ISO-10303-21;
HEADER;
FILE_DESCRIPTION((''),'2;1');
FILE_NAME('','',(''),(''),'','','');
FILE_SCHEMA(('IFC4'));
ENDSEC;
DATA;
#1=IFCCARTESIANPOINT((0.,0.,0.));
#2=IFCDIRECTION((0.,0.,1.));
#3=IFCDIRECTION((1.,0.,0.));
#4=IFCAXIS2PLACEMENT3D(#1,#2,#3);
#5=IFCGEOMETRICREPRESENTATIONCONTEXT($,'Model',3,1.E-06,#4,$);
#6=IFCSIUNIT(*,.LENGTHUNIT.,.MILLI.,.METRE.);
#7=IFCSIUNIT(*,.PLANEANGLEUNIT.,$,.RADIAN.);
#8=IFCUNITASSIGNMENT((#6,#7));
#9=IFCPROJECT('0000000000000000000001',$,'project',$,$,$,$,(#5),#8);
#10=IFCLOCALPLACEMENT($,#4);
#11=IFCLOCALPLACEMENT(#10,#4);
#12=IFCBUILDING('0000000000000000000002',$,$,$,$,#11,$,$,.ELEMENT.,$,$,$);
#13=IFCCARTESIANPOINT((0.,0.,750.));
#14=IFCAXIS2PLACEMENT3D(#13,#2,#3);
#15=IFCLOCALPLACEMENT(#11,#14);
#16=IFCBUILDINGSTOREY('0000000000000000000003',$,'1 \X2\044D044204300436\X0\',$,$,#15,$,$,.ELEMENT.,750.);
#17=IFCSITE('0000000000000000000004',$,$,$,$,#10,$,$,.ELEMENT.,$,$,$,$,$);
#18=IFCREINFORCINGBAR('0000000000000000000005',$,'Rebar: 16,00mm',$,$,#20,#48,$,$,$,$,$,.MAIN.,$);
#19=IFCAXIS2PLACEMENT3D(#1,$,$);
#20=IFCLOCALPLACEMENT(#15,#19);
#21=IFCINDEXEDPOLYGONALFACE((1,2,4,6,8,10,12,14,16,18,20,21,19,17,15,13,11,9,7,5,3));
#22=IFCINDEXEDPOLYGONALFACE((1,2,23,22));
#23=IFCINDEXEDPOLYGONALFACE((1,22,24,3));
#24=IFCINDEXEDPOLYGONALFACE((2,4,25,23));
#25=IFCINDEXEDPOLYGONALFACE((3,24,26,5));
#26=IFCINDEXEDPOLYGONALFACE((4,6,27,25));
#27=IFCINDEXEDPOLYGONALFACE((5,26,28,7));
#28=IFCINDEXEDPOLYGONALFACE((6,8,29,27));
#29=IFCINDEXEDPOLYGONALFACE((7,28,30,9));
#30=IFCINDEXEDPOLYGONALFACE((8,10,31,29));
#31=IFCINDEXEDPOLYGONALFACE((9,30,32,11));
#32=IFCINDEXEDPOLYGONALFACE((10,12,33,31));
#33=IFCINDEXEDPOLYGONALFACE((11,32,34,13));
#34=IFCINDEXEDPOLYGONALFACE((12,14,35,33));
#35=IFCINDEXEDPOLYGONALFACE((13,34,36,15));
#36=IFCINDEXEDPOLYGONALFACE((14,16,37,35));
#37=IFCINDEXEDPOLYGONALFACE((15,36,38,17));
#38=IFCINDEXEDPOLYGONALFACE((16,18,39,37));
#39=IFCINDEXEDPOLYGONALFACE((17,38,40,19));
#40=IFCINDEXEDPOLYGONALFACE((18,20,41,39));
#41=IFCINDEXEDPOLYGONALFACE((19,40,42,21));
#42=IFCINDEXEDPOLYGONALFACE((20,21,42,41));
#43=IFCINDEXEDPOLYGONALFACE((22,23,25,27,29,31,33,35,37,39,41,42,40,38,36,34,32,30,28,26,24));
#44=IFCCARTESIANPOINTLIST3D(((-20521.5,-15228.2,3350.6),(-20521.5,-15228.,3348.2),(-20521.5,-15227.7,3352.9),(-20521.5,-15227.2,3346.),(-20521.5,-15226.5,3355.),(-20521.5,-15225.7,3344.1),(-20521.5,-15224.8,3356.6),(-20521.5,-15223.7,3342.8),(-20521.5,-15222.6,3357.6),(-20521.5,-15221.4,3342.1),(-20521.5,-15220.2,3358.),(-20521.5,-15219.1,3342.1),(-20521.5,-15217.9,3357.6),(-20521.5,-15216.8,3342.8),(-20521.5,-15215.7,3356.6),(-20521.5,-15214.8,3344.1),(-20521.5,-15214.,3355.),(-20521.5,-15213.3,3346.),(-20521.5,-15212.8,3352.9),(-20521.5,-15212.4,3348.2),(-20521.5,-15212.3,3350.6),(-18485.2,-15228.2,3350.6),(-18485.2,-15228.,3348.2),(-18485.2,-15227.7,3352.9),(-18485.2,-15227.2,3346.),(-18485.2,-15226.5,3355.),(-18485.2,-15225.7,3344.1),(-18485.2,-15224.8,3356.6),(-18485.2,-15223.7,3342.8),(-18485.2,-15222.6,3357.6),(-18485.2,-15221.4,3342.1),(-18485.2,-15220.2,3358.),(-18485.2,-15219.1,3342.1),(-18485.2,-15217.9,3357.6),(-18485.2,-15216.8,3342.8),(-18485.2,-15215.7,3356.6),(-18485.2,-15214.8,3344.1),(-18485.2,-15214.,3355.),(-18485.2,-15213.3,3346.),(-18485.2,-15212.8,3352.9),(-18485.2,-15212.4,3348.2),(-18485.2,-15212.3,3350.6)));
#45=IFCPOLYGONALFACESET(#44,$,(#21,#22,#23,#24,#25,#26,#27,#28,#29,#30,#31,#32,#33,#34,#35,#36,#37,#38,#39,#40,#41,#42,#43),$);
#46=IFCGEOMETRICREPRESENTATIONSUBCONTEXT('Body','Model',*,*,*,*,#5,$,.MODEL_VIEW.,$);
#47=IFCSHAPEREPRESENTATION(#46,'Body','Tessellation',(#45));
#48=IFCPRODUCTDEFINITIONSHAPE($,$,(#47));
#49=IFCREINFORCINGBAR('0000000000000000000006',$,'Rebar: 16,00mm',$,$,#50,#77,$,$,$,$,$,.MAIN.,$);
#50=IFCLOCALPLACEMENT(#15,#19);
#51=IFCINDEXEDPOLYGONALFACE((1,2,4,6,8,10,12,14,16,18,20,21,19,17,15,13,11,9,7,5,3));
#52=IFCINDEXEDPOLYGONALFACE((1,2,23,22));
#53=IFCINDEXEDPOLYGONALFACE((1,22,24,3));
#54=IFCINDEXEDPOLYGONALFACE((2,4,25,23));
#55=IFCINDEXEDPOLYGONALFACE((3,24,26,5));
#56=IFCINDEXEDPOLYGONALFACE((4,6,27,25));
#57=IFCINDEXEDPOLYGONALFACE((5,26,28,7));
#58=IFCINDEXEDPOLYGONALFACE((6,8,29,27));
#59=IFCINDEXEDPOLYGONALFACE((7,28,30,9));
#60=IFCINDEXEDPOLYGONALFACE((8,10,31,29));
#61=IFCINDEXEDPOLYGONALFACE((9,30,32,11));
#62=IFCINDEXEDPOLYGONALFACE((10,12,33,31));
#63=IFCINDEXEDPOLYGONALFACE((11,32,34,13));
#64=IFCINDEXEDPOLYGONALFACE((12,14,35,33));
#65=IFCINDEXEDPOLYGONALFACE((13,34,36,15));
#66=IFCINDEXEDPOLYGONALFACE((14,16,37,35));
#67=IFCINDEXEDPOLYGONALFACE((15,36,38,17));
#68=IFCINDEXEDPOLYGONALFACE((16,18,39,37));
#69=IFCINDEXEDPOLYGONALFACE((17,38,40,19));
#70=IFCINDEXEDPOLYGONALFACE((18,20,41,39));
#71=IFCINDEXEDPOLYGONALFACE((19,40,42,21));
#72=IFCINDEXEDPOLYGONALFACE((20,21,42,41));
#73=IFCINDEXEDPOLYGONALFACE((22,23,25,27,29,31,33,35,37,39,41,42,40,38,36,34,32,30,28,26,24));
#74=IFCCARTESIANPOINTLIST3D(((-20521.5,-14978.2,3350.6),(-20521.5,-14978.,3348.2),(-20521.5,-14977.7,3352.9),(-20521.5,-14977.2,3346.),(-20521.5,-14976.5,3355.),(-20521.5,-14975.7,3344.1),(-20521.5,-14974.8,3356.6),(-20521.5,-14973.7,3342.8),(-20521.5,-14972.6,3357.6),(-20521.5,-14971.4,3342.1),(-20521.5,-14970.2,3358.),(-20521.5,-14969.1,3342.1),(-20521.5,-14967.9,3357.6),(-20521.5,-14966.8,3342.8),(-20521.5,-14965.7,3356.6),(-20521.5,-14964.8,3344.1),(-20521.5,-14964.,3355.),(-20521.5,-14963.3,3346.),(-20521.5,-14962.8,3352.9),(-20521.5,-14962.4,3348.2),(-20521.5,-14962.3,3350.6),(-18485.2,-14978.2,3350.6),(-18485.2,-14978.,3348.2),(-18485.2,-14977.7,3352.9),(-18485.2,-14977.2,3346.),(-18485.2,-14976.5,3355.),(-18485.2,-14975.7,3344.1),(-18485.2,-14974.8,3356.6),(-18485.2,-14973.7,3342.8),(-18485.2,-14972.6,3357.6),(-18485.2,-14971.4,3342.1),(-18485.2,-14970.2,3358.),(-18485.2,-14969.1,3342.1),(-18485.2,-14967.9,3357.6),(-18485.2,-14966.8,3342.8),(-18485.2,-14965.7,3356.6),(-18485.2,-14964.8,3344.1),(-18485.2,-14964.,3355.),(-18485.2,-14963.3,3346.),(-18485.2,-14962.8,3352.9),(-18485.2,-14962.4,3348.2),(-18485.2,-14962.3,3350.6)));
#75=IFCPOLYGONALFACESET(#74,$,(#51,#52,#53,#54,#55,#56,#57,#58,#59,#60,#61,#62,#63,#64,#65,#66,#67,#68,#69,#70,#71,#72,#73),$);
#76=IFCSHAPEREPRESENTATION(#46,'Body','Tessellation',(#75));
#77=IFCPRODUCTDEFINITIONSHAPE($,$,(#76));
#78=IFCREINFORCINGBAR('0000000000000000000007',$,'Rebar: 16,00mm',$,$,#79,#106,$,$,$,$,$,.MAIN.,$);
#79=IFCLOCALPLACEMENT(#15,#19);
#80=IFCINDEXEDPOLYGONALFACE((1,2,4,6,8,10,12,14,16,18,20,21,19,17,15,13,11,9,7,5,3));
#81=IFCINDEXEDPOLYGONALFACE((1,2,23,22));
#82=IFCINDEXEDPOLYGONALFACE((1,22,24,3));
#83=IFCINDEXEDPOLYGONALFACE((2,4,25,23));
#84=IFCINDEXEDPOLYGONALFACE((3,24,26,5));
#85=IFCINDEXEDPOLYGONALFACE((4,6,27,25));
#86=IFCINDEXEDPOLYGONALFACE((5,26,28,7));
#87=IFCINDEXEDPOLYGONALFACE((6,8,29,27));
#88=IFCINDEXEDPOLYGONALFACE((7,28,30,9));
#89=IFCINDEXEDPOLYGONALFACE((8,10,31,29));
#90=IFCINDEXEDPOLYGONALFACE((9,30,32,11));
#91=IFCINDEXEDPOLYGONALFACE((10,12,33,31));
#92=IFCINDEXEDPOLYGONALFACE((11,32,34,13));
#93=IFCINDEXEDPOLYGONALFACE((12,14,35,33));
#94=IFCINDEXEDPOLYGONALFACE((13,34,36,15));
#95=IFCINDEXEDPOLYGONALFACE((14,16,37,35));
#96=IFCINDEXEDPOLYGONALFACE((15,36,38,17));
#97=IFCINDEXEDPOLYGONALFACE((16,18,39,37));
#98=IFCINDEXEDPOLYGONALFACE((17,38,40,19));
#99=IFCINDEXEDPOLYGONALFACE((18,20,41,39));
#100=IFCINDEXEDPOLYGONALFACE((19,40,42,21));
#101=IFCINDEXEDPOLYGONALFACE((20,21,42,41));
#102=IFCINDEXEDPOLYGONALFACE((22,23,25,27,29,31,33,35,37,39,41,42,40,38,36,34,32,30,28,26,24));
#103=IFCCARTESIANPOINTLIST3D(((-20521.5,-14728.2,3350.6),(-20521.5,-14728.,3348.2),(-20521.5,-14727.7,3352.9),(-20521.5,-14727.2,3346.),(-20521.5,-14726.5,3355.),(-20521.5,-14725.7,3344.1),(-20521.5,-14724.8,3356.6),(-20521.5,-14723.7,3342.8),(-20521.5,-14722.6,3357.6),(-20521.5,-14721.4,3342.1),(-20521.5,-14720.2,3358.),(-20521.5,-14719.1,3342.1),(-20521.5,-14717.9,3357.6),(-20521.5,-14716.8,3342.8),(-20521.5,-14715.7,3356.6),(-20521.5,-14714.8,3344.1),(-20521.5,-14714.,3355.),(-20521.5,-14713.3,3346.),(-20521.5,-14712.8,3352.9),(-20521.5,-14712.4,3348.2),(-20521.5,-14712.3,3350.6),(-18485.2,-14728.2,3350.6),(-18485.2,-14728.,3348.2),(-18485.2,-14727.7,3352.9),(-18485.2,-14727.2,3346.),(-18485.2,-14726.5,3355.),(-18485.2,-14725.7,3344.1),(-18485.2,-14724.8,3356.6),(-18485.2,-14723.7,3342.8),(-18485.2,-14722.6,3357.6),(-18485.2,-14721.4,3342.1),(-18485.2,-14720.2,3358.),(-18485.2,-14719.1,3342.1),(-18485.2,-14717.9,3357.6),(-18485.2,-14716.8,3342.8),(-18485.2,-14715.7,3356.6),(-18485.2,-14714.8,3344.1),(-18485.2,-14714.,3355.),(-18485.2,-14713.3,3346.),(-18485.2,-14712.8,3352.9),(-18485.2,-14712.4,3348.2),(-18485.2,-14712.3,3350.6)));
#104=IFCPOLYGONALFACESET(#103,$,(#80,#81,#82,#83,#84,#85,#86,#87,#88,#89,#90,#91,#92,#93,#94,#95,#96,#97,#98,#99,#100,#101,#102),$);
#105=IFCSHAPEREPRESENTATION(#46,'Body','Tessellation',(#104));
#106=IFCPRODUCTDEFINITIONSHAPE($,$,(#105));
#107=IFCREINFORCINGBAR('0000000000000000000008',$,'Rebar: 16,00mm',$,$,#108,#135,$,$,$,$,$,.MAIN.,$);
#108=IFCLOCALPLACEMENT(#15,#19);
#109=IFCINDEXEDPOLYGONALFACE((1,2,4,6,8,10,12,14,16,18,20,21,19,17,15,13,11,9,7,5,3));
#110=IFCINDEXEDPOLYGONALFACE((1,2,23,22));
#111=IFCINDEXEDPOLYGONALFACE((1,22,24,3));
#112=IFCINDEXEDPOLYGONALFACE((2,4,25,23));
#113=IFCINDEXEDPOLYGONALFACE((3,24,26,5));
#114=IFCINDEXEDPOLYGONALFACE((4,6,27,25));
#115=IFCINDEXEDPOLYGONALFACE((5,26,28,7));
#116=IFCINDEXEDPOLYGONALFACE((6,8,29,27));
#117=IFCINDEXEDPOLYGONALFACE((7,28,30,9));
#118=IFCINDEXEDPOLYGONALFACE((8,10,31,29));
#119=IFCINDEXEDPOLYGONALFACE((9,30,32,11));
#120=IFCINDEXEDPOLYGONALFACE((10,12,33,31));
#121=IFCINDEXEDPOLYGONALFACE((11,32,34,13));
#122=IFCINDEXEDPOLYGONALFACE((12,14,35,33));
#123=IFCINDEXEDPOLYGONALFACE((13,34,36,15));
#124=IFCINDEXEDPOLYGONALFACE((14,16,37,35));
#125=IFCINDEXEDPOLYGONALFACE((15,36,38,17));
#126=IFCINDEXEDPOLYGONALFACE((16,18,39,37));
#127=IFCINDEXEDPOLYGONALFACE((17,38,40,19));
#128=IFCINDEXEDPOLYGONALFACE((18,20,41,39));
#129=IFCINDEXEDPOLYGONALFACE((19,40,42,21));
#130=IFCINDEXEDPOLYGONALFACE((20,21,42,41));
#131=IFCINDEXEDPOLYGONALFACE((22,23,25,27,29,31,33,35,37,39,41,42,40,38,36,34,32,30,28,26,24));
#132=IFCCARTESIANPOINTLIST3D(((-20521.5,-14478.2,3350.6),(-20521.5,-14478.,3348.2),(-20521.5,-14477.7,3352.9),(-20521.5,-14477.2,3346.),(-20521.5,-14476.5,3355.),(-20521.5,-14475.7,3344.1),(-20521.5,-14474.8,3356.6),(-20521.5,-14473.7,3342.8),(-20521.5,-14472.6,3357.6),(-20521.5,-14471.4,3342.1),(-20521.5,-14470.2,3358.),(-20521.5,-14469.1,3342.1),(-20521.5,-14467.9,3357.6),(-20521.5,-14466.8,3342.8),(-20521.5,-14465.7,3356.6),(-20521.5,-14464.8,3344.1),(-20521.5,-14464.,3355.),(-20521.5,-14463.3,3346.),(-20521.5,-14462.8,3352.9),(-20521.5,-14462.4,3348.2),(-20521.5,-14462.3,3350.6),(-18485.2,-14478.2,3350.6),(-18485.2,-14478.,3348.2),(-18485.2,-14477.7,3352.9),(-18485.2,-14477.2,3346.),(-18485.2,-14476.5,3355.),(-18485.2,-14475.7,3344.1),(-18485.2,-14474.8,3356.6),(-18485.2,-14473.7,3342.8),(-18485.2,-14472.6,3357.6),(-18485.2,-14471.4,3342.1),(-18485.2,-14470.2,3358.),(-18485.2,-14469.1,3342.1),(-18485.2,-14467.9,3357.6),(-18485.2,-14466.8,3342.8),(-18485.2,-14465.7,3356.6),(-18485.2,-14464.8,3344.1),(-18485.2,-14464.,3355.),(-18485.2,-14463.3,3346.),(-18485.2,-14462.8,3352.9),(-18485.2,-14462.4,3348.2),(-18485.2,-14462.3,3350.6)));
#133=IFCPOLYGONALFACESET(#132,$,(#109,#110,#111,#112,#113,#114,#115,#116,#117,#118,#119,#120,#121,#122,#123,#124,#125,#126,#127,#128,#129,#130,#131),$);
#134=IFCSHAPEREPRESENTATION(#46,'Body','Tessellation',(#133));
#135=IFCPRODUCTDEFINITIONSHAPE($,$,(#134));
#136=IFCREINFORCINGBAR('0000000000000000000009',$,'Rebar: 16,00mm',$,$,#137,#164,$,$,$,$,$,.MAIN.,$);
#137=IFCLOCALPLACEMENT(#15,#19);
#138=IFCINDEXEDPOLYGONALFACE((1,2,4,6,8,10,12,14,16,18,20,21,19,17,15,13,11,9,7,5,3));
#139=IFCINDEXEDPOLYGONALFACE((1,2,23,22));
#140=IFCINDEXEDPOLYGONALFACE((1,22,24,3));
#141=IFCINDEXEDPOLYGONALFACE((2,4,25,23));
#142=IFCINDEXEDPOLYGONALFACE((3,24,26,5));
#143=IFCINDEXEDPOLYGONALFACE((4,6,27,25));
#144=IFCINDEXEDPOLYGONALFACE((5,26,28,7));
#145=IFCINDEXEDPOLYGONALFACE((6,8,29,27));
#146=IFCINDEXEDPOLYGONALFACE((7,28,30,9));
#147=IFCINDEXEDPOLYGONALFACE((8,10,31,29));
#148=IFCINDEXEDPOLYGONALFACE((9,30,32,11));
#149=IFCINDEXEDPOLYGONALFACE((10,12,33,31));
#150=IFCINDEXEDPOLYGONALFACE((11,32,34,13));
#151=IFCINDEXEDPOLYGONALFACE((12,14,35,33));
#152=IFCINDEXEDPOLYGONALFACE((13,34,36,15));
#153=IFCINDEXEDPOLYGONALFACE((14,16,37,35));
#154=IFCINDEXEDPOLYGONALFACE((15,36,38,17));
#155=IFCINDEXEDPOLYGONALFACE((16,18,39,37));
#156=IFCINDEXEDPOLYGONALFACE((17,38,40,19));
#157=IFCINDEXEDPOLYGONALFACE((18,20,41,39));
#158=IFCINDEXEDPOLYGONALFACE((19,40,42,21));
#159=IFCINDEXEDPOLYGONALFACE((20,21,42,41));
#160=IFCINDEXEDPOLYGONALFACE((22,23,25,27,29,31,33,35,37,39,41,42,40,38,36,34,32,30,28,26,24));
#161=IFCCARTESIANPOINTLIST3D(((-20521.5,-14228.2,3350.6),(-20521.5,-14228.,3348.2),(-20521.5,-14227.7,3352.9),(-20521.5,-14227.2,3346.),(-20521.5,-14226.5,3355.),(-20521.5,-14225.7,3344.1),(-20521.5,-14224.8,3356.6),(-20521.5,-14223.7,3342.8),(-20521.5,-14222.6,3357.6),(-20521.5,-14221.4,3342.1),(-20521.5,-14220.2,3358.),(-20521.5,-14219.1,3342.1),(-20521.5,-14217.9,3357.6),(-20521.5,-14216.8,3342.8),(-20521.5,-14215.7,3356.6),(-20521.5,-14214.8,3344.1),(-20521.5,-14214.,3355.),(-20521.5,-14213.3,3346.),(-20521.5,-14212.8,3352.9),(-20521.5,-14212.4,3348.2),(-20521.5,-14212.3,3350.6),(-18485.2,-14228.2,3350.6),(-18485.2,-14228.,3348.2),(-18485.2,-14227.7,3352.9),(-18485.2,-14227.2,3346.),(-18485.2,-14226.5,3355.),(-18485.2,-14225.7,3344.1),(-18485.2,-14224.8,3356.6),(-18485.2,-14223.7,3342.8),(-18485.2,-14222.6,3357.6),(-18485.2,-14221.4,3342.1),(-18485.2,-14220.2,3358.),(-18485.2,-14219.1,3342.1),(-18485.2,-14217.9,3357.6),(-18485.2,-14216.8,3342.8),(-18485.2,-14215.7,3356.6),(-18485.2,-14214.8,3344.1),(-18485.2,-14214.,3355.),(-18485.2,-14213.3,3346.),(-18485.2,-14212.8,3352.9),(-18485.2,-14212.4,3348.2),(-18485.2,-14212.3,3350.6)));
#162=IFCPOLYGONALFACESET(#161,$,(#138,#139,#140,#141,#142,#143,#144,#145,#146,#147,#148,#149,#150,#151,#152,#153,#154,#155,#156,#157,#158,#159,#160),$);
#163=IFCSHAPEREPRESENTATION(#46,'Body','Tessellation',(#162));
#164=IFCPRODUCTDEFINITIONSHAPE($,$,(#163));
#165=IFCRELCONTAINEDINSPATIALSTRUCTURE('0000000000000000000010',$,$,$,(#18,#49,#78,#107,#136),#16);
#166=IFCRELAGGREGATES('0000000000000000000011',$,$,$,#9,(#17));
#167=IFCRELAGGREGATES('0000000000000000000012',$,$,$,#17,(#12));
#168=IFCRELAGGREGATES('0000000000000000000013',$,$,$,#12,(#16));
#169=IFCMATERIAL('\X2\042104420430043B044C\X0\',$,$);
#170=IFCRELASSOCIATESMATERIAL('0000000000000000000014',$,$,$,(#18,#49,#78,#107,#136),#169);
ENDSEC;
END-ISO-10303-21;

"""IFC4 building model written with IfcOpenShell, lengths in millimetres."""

from ifc_helpers import new_model, entity, si_unit, frame, origin_with_axes, place, context, subcontext, project, spatial, source, transform, mapped, material, element, save


model = new_model("IFC4")

# Units and contexts
model_context = context("Model", 3, precision=1e-06, world=origin_with_axes())
body_context = subcontext(model_context, "Body", "Model", "MODEL_VIEW")
ifc_project = project(units=[si_unit("LENGTHUNIT", "METRE", prefix="MILLI"), si_unit("PLANEANGLEUNIT", "RADIAN")], contexts=[model_context])

# Site, building, storey
site_placement = place(None, origin_with_axes())
site = spatial("IfcSite", under=ifc_project, at=site_placement, CompositionType="ELEMENT")
building_placement = place(site_placement, origin_with_axes())
building = spatial("IfcBuilding", under=site, at=building_placement, CompositionType="ELEMENT")
storey_placement = place(building_placement, frame((0.0, 0.0, 750.0), z_axis=(0.0, 0.0, 1.0), x_axis=(1.0, 0.0, 0.0)))
storey = spatial("IfcBuildingStorey", under=building, at=storey_placement, Name="1 этаж", CompositionType="ELEMENT", Elevation=750.0)

# Reinforcing bars
ifc_material = material(Name="Сталь")
shared_shape_1 = source(origin_with_axes(), body_context, "Body", "AdvancedSweptSolid", [
    entity("IfcSweptDiskSolid", entity("IfcIndexedPolyCurve", entity("IfcCartesianPointList3D", [[0.0, 0.0, 0.0], [2036.2, 0.0, 0.0]]), [entity("IfcLineIndex", [1, 2])]), 8.0),
])
reinforcing_bar_1_placement = place(storey_placement, origin_with_axes())
element("IfcReinforcingBar", 1, at=reinforcing_bar_1_placement, inside=storey, material=ifc_material, Name="Rebar: 16,00mm", PredefinedType="MAIN", context=body_context, shape_type="MappedRepresentation", body=[
    mapped(shared_shape_1, transform((-20521.5, -15220.2, 3350.0), x_axis=(1.0, 0.0, 0.0), y_axis=(0.0, 1.0, 0.0), z_axis=(0.0, 0.0, 1.0), scale=1.0)),
])
reinforcing_bar_2_placement = place(storey_placement, origin_with_axes())
element("IfcReinforcingBar", 2, at=reinforcing_bar_2_placement, inside=storey, material=ifc_material, Name="Rebar: 16,00mm", PredefinedType="MAIN", context=body_context, shape_type="MappedRepresentation", body=[
    mapped(shared_shape_1, transform((-20521.5, -14970.2, 3350.0), x_axis=(1.0, 0.0, 0.0), y_axis=(0.0, 1.0, 0.0), z_axis=(0.0, 0.0, 1.0), scale=1.0)),
])
reinforcing_bar_3_placement = place(storey_placement, origin_with_axes())
element("IfcReinforcingBar", 3, at=reinforcing_bar_3_placement, inside=storey, material=ifc_material, Name="Rebar: 16,00mm", PredefinedType="MAIN", context=body_context, shape_type="MappedRepresentation", body=[
    mapped(shared_shape_1, transform((-20521.5, -14720.2, 3350.0), x_axis=(1.0, 0.0, 0.0), y_axis=(0.0, 1.0, 0.0), z_axis=(0.0, 0.0, 1.0), scale=1.0)),
])
reinforcing_bar_4_placement = place(storey_placement, origin_with_axes())
element("IfcReinforcingBar", 4, at=reinforcing_bar_4_placement, inside=storey, material=ifc_material, Name="Rebar: 16,00mm", PredefinedType="MAIN", context=body_context, shape_type="MappedRepresentation", body=[
    mapped(shared_shape_1, transform((-20521.5, -14470.2, 3350.0), x_axis=(1.0, 0.0, 0.0), y_axis=(0.0, 1.0, 0.0), z_axis=(0.0, 0.0, 1.0), scale=1.0)),
])
reinforcing_bar_5_placement = place(storey_placement, origin_with_axes())
element("IfcReinforcingBar", 5, at=reinforcing_bar_5_placement, inside=storey, material=ifc_material, Name="Rebar: 16,00mm", PredefinedType="MAIN", context=body_context, shape_type="MappedRepresentation", body=[
    mapped(shared_shape_1, transform((-20521.5, -14220.2, 3350.0), x_axis=(1.0, 0.0, 0.0), y_axis=(0.0, 1.0, 0.0), z_axis=(0.0, 0.0, 1.0), scale=1.0)),
])

save(model, "model.ifc")
